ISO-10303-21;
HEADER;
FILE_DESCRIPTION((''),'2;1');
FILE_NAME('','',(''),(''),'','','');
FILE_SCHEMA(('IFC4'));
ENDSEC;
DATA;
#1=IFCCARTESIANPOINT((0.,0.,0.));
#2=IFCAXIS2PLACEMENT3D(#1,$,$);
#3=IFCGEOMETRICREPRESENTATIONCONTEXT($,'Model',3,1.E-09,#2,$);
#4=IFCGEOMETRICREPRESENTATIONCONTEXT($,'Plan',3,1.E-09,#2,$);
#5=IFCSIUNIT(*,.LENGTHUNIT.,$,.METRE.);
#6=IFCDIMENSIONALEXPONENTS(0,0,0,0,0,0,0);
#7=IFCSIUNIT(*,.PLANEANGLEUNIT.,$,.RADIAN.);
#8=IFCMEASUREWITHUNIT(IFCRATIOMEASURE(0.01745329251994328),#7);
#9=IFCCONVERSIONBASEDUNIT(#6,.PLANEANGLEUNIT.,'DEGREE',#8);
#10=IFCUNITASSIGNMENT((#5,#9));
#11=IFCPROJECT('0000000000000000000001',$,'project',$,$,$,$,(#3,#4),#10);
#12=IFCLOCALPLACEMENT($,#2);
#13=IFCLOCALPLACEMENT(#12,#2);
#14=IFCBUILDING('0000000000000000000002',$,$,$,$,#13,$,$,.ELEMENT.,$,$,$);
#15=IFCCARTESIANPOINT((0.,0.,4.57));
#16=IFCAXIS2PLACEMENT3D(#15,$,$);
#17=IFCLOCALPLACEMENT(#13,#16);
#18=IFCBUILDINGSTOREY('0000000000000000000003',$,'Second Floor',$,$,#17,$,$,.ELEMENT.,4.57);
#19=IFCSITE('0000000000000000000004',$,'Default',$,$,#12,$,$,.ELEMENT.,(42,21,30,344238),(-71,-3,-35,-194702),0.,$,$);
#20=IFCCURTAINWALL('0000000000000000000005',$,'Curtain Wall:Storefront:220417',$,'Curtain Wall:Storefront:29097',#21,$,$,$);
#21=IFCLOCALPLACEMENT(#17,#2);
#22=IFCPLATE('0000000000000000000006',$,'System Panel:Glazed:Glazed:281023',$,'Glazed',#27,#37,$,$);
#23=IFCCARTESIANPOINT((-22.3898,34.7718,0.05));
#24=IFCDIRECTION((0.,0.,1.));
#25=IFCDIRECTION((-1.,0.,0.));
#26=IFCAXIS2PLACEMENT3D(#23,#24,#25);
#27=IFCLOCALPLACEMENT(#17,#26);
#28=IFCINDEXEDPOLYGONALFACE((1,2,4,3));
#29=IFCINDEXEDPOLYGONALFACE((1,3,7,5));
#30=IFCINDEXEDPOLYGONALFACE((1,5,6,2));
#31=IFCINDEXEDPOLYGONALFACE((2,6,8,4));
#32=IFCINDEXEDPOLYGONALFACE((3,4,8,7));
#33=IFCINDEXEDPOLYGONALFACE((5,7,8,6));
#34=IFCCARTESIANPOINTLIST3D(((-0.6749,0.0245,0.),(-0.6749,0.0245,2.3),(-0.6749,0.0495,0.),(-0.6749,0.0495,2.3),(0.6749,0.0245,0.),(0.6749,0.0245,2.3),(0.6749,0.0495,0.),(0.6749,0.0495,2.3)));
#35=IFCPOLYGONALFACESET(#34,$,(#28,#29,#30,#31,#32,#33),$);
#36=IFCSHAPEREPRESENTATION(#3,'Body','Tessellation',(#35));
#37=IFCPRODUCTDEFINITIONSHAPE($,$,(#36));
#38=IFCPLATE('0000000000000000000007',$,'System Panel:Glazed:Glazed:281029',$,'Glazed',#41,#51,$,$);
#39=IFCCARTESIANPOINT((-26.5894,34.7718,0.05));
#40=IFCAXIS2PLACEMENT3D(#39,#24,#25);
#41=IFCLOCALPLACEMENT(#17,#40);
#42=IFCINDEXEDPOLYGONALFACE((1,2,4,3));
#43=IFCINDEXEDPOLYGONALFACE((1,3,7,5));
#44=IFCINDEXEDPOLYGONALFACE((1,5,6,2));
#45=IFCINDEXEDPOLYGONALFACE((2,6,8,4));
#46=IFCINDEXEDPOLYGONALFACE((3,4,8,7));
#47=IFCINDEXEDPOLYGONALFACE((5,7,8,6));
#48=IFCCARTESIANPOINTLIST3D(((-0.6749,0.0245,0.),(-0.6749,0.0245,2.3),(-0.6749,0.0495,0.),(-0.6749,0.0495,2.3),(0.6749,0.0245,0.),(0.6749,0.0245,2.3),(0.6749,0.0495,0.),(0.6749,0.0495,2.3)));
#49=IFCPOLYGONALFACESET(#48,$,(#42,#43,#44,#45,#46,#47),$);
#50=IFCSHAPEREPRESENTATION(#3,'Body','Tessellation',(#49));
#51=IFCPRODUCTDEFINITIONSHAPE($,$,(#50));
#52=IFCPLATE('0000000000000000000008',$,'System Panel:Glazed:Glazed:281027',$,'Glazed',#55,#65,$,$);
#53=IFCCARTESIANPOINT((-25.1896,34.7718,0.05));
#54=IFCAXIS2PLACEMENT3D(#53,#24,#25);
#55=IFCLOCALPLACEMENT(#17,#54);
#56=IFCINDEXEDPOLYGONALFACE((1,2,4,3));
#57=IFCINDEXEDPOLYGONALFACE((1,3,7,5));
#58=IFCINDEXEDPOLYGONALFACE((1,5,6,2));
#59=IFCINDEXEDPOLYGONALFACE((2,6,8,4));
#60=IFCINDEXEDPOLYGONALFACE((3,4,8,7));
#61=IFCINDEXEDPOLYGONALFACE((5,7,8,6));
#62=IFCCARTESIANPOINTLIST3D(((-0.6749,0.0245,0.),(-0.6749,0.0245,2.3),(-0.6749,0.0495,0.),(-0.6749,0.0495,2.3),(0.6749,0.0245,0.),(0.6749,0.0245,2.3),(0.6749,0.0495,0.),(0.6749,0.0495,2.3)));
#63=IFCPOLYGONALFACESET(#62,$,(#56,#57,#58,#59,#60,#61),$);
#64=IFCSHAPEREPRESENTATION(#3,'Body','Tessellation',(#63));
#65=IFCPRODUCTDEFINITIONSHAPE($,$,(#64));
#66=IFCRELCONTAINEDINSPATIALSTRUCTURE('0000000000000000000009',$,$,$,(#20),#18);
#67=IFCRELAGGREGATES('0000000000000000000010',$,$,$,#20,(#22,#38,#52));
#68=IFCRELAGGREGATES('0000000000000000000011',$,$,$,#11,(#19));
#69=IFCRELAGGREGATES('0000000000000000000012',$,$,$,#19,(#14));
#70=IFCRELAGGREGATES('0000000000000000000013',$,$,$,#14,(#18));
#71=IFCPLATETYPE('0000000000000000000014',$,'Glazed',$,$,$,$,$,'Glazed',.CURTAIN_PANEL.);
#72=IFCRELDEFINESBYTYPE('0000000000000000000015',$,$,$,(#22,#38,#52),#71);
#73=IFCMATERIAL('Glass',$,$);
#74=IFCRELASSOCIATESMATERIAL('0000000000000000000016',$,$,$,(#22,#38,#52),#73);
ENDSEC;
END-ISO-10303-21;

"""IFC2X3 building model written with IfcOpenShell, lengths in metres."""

from ifc_helpers import new_model, entity, si_unit, converted_unit, frame, origin, origin_2d_with_axis, place, context, project, spatial, rectangle, extrude, source, transform, mapped, material, type_object, type_shapes, element, aggregate, save


model = new_model("IFC2X3")

# Units and contexts
model_context = context("Model", 3, precision=1e-09, world=origin())
plan_context = context("Plan", 3, precision=1e-09, world=origin())
ifc_project = project(units=[si_unit("LENGTHUNIT", "METRE"), converted_unit("PLANEANGLEUNIT", "DEGREE", entity("IfcRatioMeasure", 0.01745329251994328), si_unit("PLANEANGLEUNIT", "RADIAN"), dimensions=[0, 0, 0, 0, 0, 0, 0])], contexts=[model_context, plan_context])

# Site, building, storey
site_placement = place(None, origin())
site = spatial("IfcSite", under=ifc_project, at=site_placement, Name="Default", CompositionType="ELEMENT", RefLatitude=(42, 21, 30, 344238), RefLongitude=(-71, -3, -35, -194702), RefElevation=0.0)
building_placement = place(site_placement, origin())
building = spatial("IfcBuilding", under=site, at=building_placement, CompositionType="ELEMENT")
storey_placement = place(building_placement, frame((0.0, 0.0, 4.57)))
storey = spatial("IfcBuildingStorey", under=building, at=storey_placement, Name="Second Floor", CompositionType="ELEMENT", Elevation=4.57)

# Curtain wall, plates
curtain_wall_placement = place(storey_placement, origin())
curtain_wall = element("IfcCurtainWall", 1, at=curtain_wall_placement, inside=storey, Name="Curtain Wall:Storefront:220417", ObjectType="Curtain Wall:Storefront:29097")
ifc_material_1 = material(Name="Glass")
plate_type = type_object("IfcPlateType", Name="Glazed", ElementType="Glazed", PredefinedType="CURTAIN_PANEL")
shared_shape_1 = source(origin(), model_context, "Body", "SweptSolid", [
    extrude(rectangle(XDim=0.025, YDim=1.3499, at=origin_2d_with_axis()), frame((0.0, 0.037, 0.0), z_axis=(0.0, 0.0, 1.0), x_axis=(0.0, 1.0, 0.0)), (0.0, 0.0, 1.0), 2.3),
])
type_shapes(plate_type, [shared_shape_1])
plate_1_placement = place(storey_placement, frame((-22.3898, 34.7718, 0.05), z_axis=(0.0, 0.0, 1.0), x_axis=(-1.0, 0.0, 0.0)))
plate_1 = element("IfcPlate", 2, at=plate_1_placement, type_object=plate_type, material=ifc_material_1, Name="System Panel:Glazed:Glazed:281023", ObjectType="Glazed", context=model_context, shape_type="MappedRepresentation", body=[
    mapped(shared_shape_1, transform((0.0, 0.0, 0.0), scale=1.0)),
])
plate_2_placement = place(storey_placement, frame((-26.5894, 34.7718, 0.05), z_axis=(0.0, 0.0, 1.0), x_axis=(-1.0, 0.0, 0.0)))
plate_2 = element("IfcPlate", 3, at=plate_2_placement, type_object=plate_type, material=ifc_material_1, Name="System Panel:Glazed:Glazed:281029", ObjectType="Glazed", context=model_context, shape_type="MappedRepresentation", body=[
    mapped(shared_shape_1, transform((0.0, 0.0, 0.0), scale=1.0)),
])
plate_3_placement = place(storey_placement, frame((-25.1896, 34.7718, 0.05), z_axis=(0.0, 0.0, 1.0), x_axis=(-1.0, 0.0, 0.0)))
plate_3 = element("IfcPlate", 4, at=plate_3_placement, type_object=plate_type, material=ifc_material_1, Name="System Panel:Glazed:Glazed:281027", ObjectType="Glazed", context=model_context, shape_type="MappedRepresentation", body=[
    mapped(shared_shape_1, transform((0.0, 0.0, 0.0), scale=1.0)),
])
aggregate(curtain_wall, [plate_1, plate_2, plate_3])

save(model, "model.ifc")
